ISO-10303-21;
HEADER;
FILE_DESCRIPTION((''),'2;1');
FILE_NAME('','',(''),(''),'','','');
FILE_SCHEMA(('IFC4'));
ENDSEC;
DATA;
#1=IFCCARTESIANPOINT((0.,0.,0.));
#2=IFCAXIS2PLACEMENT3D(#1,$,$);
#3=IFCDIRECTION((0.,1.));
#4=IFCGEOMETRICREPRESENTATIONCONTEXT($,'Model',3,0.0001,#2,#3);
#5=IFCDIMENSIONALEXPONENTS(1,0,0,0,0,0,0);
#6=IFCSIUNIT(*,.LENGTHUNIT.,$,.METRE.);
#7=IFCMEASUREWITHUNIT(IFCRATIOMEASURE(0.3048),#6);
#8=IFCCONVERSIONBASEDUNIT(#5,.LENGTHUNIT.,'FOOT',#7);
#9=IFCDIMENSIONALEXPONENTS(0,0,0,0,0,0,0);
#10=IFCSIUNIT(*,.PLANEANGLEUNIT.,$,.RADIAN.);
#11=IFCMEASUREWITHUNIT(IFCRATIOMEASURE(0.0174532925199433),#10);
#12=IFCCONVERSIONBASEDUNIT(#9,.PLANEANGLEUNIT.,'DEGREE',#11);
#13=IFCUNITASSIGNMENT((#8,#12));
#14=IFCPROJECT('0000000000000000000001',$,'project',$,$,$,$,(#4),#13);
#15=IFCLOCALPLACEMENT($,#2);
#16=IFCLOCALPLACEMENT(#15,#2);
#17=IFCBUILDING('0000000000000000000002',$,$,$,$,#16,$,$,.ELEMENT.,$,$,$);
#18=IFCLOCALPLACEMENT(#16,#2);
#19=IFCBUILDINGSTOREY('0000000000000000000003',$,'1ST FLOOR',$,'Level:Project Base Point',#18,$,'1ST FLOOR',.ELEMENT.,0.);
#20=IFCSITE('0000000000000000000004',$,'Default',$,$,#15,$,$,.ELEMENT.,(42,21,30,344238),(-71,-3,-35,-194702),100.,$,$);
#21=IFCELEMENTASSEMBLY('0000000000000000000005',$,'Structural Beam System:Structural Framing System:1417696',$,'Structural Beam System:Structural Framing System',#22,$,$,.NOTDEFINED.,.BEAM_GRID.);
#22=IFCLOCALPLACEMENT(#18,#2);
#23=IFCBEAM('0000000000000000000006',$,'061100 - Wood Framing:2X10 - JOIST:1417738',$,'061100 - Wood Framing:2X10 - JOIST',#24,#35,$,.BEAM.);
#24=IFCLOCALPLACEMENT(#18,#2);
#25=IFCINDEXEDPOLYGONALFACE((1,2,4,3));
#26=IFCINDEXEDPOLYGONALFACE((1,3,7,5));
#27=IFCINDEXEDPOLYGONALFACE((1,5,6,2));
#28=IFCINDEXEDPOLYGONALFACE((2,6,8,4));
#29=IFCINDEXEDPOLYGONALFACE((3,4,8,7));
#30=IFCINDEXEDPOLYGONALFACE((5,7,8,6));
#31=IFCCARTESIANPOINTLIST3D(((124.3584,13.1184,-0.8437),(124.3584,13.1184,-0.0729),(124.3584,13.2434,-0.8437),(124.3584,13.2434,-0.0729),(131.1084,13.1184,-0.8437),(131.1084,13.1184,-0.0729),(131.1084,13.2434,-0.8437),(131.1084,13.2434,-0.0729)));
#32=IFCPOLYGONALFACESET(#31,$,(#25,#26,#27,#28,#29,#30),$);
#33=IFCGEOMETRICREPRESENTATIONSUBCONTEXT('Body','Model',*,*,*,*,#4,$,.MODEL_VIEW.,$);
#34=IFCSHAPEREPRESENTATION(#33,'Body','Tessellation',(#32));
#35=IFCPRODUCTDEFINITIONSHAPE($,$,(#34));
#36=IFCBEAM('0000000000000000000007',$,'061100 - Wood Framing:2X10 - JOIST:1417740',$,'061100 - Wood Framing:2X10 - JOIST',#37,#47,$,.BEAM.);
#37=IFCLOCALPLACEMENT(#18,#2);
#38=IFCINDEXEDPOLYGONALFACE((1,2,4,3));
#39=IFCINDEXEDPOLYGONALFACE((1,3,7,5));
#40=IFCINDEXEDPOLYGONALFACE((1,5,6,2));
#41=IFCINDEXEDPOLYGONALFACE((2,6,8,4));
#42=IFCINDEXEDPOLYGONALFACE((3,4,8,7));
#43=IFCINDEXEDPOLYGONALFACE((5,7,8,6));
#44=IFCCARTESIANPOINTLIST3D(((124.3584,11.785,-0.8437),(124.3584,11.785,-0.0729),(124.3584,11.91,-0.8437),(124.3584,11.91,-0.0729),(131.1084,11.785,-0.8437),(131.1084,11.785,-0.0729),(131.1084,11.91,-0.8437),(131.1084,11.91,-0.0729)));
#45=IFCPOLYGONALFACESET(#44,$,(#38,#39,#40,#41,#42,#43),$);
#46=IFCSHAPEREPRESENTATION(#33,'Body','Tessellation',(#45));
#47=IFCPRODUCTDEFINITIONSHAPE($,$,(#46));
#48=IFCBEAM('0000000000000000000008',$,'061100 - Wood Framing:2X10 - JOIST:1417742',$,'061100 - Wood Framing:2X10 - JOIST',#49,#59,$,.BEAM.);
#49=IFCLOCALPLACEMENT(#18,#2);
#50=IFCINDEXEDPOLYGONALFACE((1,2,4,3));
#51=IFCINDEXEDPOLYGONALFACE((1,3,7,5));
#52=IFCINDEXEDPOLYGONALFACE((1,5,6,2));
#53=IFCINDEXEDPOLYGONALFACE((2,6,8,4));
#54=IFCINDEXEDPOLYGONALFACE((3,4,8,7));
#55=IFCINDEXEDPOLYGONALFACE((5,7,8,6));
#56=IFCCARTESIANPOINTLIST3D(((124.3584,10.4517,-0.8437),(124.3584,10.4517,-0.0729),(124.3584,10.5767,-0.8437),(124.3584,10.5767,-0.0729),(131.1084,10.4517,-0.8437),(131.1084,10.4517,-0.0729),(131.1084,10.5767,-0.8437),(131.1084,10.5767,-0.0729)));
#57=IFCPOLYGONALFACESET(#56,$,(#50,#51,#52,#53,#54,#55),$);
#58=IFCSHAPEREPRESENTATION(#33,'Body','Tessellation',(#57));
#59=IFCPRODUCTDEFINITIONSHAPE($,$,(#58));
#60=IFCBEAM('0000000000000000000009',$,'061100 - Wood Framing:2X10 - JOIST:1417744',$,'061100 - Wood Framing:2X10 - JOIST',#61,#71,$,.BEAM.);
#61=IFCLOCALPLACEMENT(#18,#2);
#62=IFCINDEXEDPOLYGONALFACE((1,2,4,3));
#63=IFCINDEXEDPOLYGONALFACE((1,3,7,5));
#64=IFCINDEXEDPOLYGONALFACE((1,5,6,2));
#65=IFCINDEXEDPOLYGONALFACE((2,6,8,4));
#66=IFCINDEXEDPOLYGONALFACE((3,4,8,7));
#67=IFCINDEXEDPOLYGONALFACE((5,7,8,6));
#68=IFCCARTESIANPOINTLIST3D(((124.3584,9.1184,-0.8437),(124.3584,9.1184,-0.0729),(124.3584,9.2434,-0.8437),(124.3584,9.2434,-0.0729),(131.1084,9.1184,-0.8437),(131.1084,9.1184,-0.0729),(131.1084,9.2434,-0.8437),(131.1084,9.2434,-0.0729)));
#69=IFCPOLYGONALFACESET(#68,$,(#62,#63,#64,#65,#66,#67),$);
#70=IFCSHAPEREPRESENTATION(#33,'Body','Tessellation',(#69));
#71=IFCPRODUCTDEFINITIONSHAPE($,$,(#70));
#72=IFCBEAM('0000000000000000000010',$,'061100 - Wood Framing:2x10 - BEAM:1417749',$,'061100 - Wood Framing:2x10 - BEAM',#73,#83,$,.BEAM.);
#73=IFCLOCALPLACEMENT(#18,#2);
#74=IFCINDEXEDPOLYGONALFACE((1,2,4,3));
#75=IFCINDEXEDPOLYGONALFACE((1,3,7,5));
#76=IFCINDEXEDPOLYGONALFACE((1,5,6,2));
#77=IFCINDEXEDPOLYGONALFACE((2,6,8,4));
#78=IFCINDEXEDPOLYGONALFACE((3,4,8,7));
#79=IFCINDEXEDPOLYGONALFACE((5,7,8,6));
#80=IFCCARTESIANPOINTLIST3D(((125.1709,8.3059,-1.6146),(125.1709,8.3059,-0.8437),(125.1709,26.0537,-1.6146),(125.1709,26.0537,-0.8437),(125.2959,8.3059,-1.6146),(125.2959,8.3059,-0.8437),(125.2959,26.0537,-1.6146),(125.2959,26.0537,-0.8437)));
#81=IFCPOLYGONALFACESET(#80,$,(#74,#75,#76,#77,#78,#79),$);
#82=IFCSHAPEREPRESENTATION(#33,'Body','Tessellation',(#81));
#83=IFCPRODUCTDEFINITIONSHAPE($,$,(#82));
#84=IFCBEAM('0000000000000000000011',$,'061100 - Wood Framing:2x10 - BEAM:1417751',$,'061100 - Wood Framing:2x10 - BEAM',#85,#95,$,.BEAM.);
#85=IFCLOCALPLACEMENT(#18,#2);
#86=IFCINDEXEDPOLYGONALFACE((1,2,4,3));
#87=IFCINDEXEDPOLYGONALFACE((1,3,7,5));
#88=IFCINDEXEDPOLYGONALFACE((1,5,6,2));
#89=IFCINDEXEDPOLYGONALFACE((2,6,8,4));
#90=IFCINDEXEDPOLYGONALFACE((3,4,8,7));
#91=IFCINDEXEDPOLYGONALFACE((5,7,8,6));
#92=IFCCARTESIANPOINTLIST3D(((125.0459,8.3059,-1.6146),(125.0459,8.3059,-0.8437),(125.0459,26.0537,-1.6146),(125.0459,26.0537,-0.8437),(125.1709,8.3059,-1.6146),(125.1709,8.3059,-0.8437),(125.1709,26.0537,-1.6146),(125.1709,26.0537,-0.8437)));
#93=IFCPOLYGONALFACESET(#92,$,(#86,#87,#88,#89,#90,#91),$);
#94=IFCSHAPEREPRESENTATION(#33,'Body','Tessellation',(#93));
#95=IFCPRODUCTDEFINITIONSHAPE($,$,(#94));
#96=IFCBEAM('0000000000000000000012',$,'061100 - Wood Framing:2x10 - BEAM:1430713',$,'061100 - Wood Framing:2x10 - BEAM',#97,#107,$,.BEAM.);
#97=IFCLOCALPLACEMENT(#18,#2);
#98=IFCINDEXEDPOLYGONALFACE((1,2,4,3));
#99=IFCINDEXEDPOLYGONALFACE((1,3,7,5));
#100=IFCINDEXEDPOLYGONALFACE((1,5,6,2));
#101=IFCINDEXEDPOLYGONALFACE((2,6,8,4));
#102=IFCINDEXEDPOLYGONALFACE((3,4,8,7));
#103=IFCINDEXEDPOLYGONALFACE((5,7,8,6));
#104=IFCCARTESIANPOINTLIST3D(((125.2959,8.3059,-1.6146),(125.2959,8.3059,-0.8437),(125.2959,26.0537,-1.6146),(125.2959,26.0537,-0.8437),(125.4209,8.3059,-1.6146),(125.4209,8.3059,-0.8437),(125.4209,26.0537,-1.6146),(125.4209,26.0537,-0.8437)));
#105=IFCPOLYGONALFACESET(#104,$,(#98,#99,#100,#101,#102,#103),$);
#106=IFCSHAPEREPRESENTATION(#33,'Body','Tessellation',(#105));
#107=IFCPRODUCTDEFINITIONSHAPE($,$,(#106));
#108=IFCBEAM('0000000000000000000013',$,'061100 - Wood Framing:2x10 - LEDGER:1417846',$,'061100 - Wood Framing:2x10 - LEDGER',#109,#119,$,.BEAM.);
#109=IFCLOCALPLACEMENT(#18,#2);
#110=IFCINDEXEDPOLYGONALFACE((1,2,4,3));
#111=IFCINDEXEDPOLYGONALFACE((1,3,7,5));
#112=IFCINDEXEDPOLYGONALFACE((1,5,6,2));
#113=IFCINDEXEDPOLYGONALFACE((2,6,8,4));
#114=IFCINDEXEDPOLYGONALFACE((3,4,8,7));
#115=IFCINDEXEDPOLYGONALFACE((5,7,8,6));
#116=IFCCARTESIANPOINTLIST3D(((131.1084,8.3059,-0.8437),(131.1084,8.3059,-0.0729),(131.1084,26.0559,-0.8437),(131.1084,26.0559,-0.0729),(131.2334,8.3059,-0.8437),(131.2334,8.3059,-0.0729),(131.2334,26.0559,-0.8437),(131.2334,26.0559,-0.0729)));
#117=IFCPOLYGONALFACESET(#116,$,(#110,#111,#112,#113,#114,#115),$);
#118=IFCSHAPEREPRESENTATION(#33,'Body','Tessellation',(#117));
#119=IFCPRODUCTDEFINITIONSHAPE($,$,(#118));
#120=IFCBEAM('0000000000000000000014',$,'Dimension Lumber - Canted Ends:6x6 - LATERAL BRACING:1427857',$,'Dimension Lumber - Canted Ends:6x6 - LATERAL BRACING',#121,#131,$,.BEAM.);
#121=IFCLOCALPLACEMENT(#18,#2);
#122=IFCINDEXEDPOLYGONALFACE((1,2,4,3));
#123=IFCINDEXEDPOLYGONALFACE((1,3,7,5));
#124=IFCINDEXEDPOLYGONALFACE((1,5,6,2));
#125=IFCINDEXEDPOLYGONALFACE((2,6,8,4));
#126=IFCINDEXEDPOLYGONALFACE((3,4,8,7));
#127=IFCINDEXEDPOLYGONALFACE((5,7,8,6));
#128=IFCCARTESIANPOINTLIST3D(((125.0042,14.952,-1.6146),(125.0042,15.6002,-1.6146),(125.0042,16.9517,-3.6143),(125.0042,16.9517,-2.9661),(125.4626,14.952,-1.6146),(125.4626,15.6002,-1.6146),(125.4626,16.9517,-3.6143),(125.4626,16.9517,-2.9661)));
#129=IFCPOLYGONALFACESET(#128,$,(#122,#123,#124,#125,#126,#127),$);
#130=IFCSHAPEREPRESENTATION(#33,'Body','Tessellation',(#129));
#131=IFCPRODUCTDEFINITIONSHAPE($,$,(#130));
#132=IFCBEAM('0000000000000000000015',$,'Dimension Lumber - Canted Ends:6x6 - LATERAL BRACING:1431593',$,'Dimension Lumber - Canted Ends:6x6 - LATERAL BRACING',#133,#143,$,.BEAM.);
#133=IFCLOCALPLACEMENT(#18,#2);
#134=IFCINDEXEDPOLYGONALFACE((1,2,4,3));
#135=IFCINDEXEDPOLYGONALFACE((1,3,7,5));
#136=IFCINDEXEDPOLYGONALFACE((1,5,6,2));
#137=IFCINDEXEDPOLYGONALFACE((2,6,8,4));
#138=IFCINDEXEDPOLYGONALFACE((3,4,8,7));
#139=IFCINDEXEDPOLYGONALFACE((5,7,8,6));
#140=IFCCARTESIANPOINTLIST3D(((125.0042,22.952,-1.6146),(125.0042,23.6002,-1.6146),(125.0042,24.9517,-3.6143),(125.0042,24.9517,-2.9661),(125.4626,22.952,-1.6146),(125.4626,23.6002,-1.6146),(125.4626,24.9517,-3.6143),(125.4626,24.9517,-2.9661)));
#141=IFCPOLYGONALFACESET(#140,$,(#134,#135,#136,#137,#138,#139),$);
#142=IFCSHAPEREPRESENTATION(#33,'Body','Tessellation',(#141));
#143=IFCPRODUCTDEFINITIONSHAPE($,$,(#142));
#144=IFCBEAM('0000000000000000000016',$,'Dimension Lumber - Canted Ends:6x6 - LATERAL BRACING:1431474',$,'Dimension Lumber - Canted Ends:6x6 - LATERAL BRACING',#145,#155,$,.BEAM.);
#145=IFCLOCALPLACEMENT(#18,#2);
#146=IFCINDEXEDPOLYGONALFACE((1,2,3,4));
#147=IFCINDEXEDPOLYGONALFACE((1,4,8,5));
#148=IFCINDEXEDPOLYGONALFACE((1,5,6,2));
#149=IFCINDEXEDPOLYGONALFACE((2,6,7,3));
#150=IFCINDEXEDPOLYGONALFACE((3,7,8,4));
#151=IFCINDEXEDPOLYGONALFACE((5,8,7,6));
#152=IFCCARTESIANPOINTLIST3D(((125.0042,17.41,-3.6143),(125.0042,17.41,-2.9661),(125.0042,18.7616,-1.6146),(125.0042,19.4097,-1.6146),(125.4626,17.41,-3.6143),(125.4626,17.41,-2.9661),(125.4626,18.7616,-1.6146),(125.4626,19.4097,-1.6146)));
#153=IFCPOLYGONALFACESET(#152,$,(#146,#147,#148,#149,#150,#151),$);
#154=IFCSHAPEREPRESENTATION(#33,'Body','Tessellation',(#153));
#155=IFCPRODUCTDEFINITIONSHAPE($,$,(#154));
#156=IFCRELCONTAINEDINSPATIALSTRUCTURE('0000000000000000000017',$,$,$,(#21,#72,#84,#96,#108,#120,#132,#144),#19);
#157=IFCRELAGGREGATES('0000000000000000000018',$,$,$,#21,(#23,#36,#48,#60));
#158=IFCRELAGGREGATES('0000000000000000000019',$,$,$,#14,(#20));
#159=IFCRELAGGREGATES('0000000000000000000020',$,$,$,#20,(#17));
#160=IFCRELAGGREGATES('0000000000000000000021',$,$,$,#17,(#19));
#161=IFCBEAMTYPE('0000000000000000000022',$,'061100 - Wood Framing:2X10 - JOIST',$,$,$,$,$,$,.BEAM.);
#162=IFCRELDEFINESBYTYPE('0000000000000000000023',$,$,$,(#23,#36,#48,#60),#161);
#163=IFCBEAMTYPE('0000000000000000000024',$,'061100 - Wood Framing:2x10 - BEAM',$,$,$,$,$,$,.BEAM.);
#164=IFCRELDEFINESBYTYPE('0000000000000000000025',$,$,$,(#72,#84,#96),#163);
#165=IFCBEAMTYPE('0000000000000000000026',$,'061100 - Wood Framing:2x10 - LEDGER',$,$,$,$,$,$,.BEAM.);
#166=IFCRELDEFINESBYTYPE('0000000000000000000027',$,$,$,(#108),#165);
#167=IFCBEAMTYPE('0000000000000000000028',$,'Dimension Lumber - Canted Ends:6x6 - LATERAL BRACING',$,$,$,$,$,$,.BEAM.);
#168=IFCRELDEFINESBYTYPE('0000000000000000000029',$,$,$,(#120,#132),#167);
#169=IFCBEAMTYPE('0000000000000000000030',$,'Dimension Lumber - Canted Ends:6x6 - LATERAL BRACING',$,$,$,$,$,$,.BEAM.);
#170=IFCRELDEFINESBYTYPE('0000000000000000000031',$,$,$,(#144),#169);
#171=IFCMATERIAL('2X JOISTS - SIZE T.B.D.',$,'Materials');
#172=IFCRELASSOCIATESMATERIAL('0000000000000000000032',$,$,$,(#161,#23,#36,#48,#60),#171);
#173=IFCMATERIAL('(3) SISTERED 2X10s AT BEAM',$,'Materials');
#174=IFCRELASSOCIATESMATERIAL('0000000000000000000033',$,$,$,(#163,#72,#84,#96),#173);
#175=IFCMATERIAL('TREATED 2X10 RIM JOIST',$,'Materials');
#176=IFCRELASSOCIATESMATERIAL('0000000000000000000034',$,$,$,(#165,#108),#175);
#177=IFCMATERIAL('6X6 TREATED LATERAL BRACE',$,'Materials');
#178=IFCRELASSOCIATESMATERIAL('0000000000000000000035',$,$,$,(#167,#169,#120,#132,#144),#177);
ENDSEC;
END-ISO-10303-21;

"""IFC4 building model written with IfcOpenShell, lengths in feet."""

from ifc_helpers import new_model, entity, si_unit, converted_unit, direction, frame, frame_2d, origin, origin_2d_with_axis, place, context, subcontext, project, spatial, rectangle, extrude, clip, halfspace, source, transform, mapped, material, material_profile, profile_set, profile_usage, type_object, type_shapes, element, aggregate, save


model = new_model("IFC4")

# Units and contexts
model_context = context("Model", 3, precision=0.0001, world=origin(), true_north=direction((0.0, 1.0)))
body_context = subcontext(model_context, "Body", "Model", "MODEL_VIEW")
ifc_project = project(units=[converted_unit("LENGTHUNIT", "FOOT", entity("IfcRatioMeasure", 0.3048), si_unit("LENGTHUNIT", "METRE"), dimensions=[1, 0, 0, 0, 0, 0, 0]), converted_unit("PLANEANGLEUNIT", "DEGREE", entity("IfcRatioMeasure", 0.0174532925199433), si_unit("PLANEANGLEUNIT", "RADIAN"), dimensions=[0, 0, 0, 0, 0, 0, 0])], contexts=[model_context])

# Site, building, storey
site_placement = place(None, origin())
site = spatial("IfcSite", under=ifc_project, at=site_placement, Name="Default", CompositionType="ELEMENT", RefLatitude=(42, 21, 30, 344238), RefLongitude=(-71, -3, -35, -194702), RefElevation=100.0)
building_placement = place(site_placement, origin())
building = spatial("IfcBuilding", under=site, at=building_placement, CompositionType="ELEMENT")
storey_placement = place(building_placement, origin())
storey = spatial("IfcBuildingStorey", under=building, at=storey_placement, Name="1ST FLOOR", ObjectType="Level:Project Base Point", LongName="1ST FLOOR", CompositionType="ELEMENT", Elevation=0.0)

# Shared definitions
ifc_material_1 = material(Name="TREATED 2X10 RIM JOIST", Category="Materials")

# Element assembly, beams
assembly_placement = place(storey_placement, origin())
assembly = element("IfcElementAssembly", 1, at=assembly_placement, inside=storey, Name="Structural Beam System:Structural Framing System:1417696", ObjectType="Structural Beam System:Structural Framing System", AssemblyPlace="NOTDEFINED", PredefinedType="BEAM_GRID")
ifc_material_2 = material(Name="2X JOISTS - SIZE T.B.D.", Category="Materials")
ifc_material_profile_1 = material_profile(ifc_material_2, rectangle(XDim=0.7708, YDim=0.125, at=frame_2d((0.0, 0.0), x_axis=(1.0, 0.0))), Name="2X10 - JOIST")
ifc_profile_set_1 = profile_set([ifc_material_profile_1], Name="2X10 - JOIST")
beam_type_1 = type_object("IfcBeamType", Name="061100 - Wood Framing:2X10 - JOIST", PredefinedType="BEAM", material=ifc_profile_set_1)
shared_shape_1 = source(origin(), body_context, "Body", "SweptSolid", [
    extrude(rectangle(XDim=0.7708, YDim=0.125, at=frame_2d((0.0, 0.0), x_axis=(1.0, 0.0))), frame((-3.375, 0.0, 0.0), z_axis=(1.0, 0.0, 0.0), x_axis=(0.0, 0.0, -1.0)), (0.0, 0.0, 1.0), 6.75),
])
type_shapes(beam_type_1, [shared_shape_1])
ifc_profile_usage_1 = profile_usage(ifc_profile_set_1, cardinal=8)
beam_1_placement = place(assembly_placement, frame((127.7334, 13.1809, -0.4583)))
beam_1 = element("IfcBeam", 2, at=beam_1_placement, type_object=beam_type_1, material=ifc_profile_usage_1, Name="061100 - Wood Framing:2X10 - JOIST:1417738", ObjectType="061100 - Wood Framing:2X10 - JOIST", PredefinedType="BEAM", context=body_context, shape_type="MappedRepresentation", body=[
    mapped(shared_shape_1, transform((0.0, 0.0, 0.0), scale=1.0)),
])
ifc_profile_usage_2 = profile_usage(ifc_profile_set_1, cardinal=8)
beam_2_placement = place(assembly_placement, frame((127.7334, 11.8475, -0.4583)))
beam_2 = element("IfcBeam", 3, at=beam_2_placement, type_object=beam_type_1, material=ifc_profile_usage_2, Name="061100 - Wood Framing:2X10 - JOIST:1417740", ObjectType="061100 - Wood Framing:2X10 - JOIST", PredefinedType="BEAM", context=body_context, shape_type="MappedRepresentation", body=[
    mapped(shared_shape_1, transform((0.0, 0.0, 0.0), scale=1.0)),
])
ifc_profile_usage_3 = profile_usage(ifc_profile_set_1, cardinal=8)
beam_3_placement = place(assembly_placement, frame((127.7334, 10.5142, -0.4583)))
beam_3 = element("IfcBeam", 4, at=beam_3_placement, type_object=beam_type_1, material=ifc_profile_usage_3, Name="061100 - Wood Framing:2X10 - JOIST:1417742", ObjectType="061100 - Wood Framing:2X10 - JOIST", PredefinedType="BEAM", context=body_context, shape_type="MappedRepresentation", body=[
    mapped(shared_shape_1, transform((0.0, 0.0, 0.0), scale=1.0)),
])
ifc_profile_usage_4 = profile_usage(ifc_profile_set_1, cardinal=8)
beam_4_placement = place(assembly_placement, frame((127.7334, 9.1809, -0.4583)))
beam_4 = element("IfcBeam", 5, at=beam_4_placement, type_object=beam_type_1, material=ifc_profile_usage_4, Name="061100 - Wood Framing:2X10 - JOIST:1417744", ObjectType="061100 - Wood Framing:2X10 - JOIST", PredefinedType="BEAM", context=body_context, shape_type="MappedRepresentation", body=[
    mapped(shared_shape_1, transform((0.0, 0.0, 0.0), scale=1.0)),
])
aggregate(assembly, [beam_1, beam_2, beam_3, beam_4])

# Beams
ifc_material_3 = material(Name="(3) SISTERED 2X10s AT BEAM", Category="Materials")
ifc_material_profile_2 = material_profile(ifc_material_3, rectangle(XDim=0.7708, YDim=0.125, at=frame_2d((0.0, 0.0), x_axis=(1.0, 0.0))), Name="2x10 - BEAM")
ifc_profile_set_2 = profile_set([ifc_material_profile_2], Name="2x10 - BEAM")
ifc_profile_usage_5 = profile_usage(ifc_profile_set_2, cardinal=8)
beam_type_2 = type_object("IfcBeamType", Name="061100 - Wood Framing:2x10 - BEAM", PredefinedType="BEAM", material=ifc_profile_set_2)
shared_shape_2 = source(origin(), body_context, "Body", "SweptSolid", [
    extrude(rectangle(XDim=0.7708, YDim=0.125, at=frame_2d((0.0, 0.0), x_axis=(1.0, 0.0))), frame((-8.8427, 0.0, 0.0), z_axis=(1.0, 0.0, 0.0), x_axis=(0.0, 0.0, -1.0)), (0.0, 0.0, 1.0), 17.7478),
])
type_shapes(beam_type_2, [shared_shape_2])
beam_5_placement = place(storey_placement, frame((125.2334, 17.1485, -1.2292), z_axis=(0.0, 0.0, 1.0), x_axis=(0.0, 1.0, 0.0)))
element("IfcBeam", 6, at=beam_5_placement, inside=storey, type_object=beam_type_2, material=ifc_profile_usage_5, Name="061100 - Wood Framing:2x10 - BEAM:1417749", ObjectType="061100 - Wood Framing:2x10 - BEAM", PredefinedType="BEAM", context=body_context, shape_type="MappedRepresentation", body=[
    mapped(shared_shape_2, transform((0.0, 0.0, 0.0), scale=1.0)),
])
ifc_profile_usage_6 = profile_usage(ifc_profile_set_2, cardinal=8)
beam_6_placement = place(storey_placement, frame((125.1084, 17.1485, -1.2292), z_axis=(0.0, 0.0, 1.0), x_axis=(0.0, 1.0, 0.0)))
element("IfcBeam", 7, at=beam_6_placement, inside=storey, type_object=beam_type_2, material=ifc_profile_usage_6, Name="061100 - Wood Framing:2x10 - BEAM:1417751", ObjectType="061100 - Wood Framing:2x10 - BEAM", PredefinedType="BEAM", context=body_context, shape_type="MappedRepresentation", body=[
    mapped(shared_shape_2, transform((0.0, 0.0, 0.0), scale=1.0)),
])
ifc_profile_usage_7 = profile_usage(ifc_profile_set_2, cardinal=8)
beam_7_placement = place(storey_placement, frame((125.3584, 17.1485, -1.2292), z_axis=(0.0, 0.0, 1.0), x_axis=(0.0, 1.0, 0.0)))
element("IfcBeam", 8, at=beam_7_placement, inside=storey, type_object=beam_type_2, material=ifc_profile_usage_7, Name="061100 - Wood Framing:2x10 - BEAM:1430713", ObjectType="061100 - Wood Framing:2x10 - BEAM", PredefinedType="BEAM", context=body_context, shape_type="MappedRepresentation", body=[
    mapped(shared_shape_2, transform((0.0, 0.0, 0.0), scale=1.0)),
])
ifc_material_profile_3 = material_profile(ifc_material_1, rectangle(XDim=0.7708, YDim=0.125, at=frame_2d((0.0, 0.0), x_axis=(1.0, 0.0))), Name="2x10 - LEDGER")
ifc_profile_set_3 = profile_set([ifc_material_profile_3], Name="2x10 - LEDGER")
ifc_profile_usage_8 = profile_usage(ifc_profile_set_3, cardinal=8)
beam_type_3 = type_object("IfcBeamType", Name="061100 - Wood Framing:2x10 - LEDGER", PredefinedType="BEAM", material=ifc_profile_set_3)
shared_shape_3 = source(origin(), body_context, "Body", "SweptSolid", [
    extrude(rectangle(XDim=0.7708, YDim=0.125, at=frame_2d((0.0, 0.0), x_axis=(1.0, 0.0))), frame((-8.875, 0.0, 0.0), z_axis=(1.0, 0.0, 0.0), x_axis=(0.0, 0.0, -1.0)), (0.0, 0.0, 1.0), 17.75),
])
type_shapes(beam_type_3, [shared_shape_3])
beam_8_placement = place(storey_placement, frame((131.1709, 17.1809, -0.4583), z_axis=(0.0, 0.0, 1.0), x_axis=(0.0, -1.0, 0.0)))
element("IfcBeam", 9, at=beam_8_placement, inside=storey, type_object=beam_type_3, material=ifc_profile_usage_8, Name="061100 - Wood Framing:2x10 - LEDGER:1417846", ObjectType="061100 - Wood Framing:2x10 - LEDGER", PredefinedType="BEAM", context=body_context, shape_type="MappedRepresentation", body=[
    mapped(shared_shape_3, transform((0.0, 0.0, 0.0), scale=1.0)),
])
ifc_material_4 = material(Name="6X6 TREATED LATERAL BRACE", Category="Materials")
ifc_material_profile_4 = material_profile(ifc_material_4, rectangle(XDim=0.4583, YDim=0.4583, at=origin_2d_with_axis()), Name="6x6 - LATERAL BRACING")
ifc_profile_set_4 = profile_set([ifc_material_profile_4], Name="6x6 - LATERAL BRACING")
ifc_profile_usage_9 = profile_usage(ifc_profile_set_4, cardinal=2)
beam_type_4 = type_object("IfcBeamType", Name="Dimension Lumber - Canted Ends:6x6 - LATERAL BRACING", PredefinedType="BEAM", material=ifc_profile_set_4)
shared_shape_4 = source(origin(), body_context, "Body", "Clipping", [
    clip(clip(extrude(rectangle(XDim=0.4583, YDim=0.4583, at=origin_2d_with_axis()), frame((-1.414, 0.0, 0.0), z_axis=(1.0, 0.0, 0.0), x_axis=(0.0, 0.0, -1.0)), (0.0, 0.0, 1.0), 2.828), halfspace(frame((-0.9557, 0.2292, 0.2292), z_axis=(-0.707107, 0.0, 0.707107), x_axis=(0.0, -1.0, 0.0)), False)), halfspace(frame((1.414, 0.2292, -0.2292), z_axis=(0.707107, 0.0, 0.707107), x_axis=(0.0, -1.0, 0.0)), False)),
])
type_shapes(beam_type_4, [shared_shape_4])
beam_9_placement = place(storey_placement, frame((125.2334, 16.1139, -2.4524), z_axis=(0.0, 0.707107, 0.707107), x_axis=(0.0, 0.707107, -0.707107)))
element("IfcBeam", 10, at=beam_9_placement, inside=storey, type_object=beam_type_4, material=ifc_profile_usage_9, Name="Dimension Lumber - Canted Ends:6x6 - LATERAL BRACING:1427857", ObjectType="Dimension Lumber - Canted Ends:6x6 - LATERAL BRACING", PredefinedType="BEAM", context=body_context, shape_type="MappedRepresentation", body=[
    mapped(shared_shape_4, transform((0.0, 0.0, 0.0), scale=1.0)),
])
ifc_profile_usage_10 = profile_usage(ifc_profile_set_4, cardinal=2)
beam_10_placement = place(storey_placement, frame((125.2334, 24.1139, -2.4524), z_axis=(0.0, 0.707107, 0.707107), x_axis=(0.0, 0.707107, -0.707107)))
element("IfcBeam", 11, at=beam_10_placement, inside=storey, type_object=beam_type_4, material=ifc_profile_usage_10, Name="Dimension Lumber - Canted Ends:6x6 - LATERAL BRACING:1431593", ObjectType="Dimension Lumber - Canted Ends:6x6 - LATERAL BRACING", PredefinedType="BEAM", context=body_context, shape_type="MappedRepresentation", body=[
    mapped(shared_shape_4, transform((0.0, 0.0, 0.0), scale=1.0)),
])
ifc_profile_usage_11 = profile_usage(ifc_profile_set_4, cardinal=2)
beam_type_5 = type_object("IfcBeamType", Name="Dimension Lumber - Canted Ends:6x6 - LATERAL BRACING", PredefinedType="BEAM", material=ifc_profile_set_4)
shared_shape_5 = source(origin(), body_context, "Body", "Clipping", [
    clip(clip(extrude(rectangle(XDim=0.4583, YDim=0.4583, at=frame_2d((0.0, 0.0), x_axis=(1.0, 0.0))), frame((-1.414, 0.0, 0.0), z_axis=(1.0, 0.0, 0.0), x_axis=(0.0, 0.0, -1.0)), (0.0, 0.0, 1.0), 2.828), halfspace(frame((-0.9557, -0.2292, 0.2292), z_axis=(-0.707107, 0.0, 0.707107), x_axis=(0.0, 1.0, 0.0)), False)), halfspace(frame((1.414, -0.2292, -0.2292), z_axis=(0.707107, 0.0, 0.707107), x_axis=(0.0, 1.0, 0.0)), False)),
])
type_shapes(beam_type_5, [shared_shape_5])
beam_11_placement = place(storey_placement, frame((125.2334, 18.2478, -2.4524), z_axis=(0.0, -0.707107, 0.707107), x_axis=(0.0, -0.707107, -0.707107)))
element("IfcBeam", 12, at=beam_11_placement, inside=storey, type_object=beam_type_5, material=ifc_profile_usage_11, Name="Dimension Lumber - Canted Ends:6x6 - LATERAL BRACING:1431474", ObjectType="Dimension Lumber - Canted Ends:6x6 - LATERAL BRACING", PredefinedType="BEAM", context=body_context, shape_type="MappedRepresentation", body=[
    mapped(shared_shape_5, transform((0.0, 0.0, 0.0), scale=1.0)),
])

save(model, "model.ifc")
